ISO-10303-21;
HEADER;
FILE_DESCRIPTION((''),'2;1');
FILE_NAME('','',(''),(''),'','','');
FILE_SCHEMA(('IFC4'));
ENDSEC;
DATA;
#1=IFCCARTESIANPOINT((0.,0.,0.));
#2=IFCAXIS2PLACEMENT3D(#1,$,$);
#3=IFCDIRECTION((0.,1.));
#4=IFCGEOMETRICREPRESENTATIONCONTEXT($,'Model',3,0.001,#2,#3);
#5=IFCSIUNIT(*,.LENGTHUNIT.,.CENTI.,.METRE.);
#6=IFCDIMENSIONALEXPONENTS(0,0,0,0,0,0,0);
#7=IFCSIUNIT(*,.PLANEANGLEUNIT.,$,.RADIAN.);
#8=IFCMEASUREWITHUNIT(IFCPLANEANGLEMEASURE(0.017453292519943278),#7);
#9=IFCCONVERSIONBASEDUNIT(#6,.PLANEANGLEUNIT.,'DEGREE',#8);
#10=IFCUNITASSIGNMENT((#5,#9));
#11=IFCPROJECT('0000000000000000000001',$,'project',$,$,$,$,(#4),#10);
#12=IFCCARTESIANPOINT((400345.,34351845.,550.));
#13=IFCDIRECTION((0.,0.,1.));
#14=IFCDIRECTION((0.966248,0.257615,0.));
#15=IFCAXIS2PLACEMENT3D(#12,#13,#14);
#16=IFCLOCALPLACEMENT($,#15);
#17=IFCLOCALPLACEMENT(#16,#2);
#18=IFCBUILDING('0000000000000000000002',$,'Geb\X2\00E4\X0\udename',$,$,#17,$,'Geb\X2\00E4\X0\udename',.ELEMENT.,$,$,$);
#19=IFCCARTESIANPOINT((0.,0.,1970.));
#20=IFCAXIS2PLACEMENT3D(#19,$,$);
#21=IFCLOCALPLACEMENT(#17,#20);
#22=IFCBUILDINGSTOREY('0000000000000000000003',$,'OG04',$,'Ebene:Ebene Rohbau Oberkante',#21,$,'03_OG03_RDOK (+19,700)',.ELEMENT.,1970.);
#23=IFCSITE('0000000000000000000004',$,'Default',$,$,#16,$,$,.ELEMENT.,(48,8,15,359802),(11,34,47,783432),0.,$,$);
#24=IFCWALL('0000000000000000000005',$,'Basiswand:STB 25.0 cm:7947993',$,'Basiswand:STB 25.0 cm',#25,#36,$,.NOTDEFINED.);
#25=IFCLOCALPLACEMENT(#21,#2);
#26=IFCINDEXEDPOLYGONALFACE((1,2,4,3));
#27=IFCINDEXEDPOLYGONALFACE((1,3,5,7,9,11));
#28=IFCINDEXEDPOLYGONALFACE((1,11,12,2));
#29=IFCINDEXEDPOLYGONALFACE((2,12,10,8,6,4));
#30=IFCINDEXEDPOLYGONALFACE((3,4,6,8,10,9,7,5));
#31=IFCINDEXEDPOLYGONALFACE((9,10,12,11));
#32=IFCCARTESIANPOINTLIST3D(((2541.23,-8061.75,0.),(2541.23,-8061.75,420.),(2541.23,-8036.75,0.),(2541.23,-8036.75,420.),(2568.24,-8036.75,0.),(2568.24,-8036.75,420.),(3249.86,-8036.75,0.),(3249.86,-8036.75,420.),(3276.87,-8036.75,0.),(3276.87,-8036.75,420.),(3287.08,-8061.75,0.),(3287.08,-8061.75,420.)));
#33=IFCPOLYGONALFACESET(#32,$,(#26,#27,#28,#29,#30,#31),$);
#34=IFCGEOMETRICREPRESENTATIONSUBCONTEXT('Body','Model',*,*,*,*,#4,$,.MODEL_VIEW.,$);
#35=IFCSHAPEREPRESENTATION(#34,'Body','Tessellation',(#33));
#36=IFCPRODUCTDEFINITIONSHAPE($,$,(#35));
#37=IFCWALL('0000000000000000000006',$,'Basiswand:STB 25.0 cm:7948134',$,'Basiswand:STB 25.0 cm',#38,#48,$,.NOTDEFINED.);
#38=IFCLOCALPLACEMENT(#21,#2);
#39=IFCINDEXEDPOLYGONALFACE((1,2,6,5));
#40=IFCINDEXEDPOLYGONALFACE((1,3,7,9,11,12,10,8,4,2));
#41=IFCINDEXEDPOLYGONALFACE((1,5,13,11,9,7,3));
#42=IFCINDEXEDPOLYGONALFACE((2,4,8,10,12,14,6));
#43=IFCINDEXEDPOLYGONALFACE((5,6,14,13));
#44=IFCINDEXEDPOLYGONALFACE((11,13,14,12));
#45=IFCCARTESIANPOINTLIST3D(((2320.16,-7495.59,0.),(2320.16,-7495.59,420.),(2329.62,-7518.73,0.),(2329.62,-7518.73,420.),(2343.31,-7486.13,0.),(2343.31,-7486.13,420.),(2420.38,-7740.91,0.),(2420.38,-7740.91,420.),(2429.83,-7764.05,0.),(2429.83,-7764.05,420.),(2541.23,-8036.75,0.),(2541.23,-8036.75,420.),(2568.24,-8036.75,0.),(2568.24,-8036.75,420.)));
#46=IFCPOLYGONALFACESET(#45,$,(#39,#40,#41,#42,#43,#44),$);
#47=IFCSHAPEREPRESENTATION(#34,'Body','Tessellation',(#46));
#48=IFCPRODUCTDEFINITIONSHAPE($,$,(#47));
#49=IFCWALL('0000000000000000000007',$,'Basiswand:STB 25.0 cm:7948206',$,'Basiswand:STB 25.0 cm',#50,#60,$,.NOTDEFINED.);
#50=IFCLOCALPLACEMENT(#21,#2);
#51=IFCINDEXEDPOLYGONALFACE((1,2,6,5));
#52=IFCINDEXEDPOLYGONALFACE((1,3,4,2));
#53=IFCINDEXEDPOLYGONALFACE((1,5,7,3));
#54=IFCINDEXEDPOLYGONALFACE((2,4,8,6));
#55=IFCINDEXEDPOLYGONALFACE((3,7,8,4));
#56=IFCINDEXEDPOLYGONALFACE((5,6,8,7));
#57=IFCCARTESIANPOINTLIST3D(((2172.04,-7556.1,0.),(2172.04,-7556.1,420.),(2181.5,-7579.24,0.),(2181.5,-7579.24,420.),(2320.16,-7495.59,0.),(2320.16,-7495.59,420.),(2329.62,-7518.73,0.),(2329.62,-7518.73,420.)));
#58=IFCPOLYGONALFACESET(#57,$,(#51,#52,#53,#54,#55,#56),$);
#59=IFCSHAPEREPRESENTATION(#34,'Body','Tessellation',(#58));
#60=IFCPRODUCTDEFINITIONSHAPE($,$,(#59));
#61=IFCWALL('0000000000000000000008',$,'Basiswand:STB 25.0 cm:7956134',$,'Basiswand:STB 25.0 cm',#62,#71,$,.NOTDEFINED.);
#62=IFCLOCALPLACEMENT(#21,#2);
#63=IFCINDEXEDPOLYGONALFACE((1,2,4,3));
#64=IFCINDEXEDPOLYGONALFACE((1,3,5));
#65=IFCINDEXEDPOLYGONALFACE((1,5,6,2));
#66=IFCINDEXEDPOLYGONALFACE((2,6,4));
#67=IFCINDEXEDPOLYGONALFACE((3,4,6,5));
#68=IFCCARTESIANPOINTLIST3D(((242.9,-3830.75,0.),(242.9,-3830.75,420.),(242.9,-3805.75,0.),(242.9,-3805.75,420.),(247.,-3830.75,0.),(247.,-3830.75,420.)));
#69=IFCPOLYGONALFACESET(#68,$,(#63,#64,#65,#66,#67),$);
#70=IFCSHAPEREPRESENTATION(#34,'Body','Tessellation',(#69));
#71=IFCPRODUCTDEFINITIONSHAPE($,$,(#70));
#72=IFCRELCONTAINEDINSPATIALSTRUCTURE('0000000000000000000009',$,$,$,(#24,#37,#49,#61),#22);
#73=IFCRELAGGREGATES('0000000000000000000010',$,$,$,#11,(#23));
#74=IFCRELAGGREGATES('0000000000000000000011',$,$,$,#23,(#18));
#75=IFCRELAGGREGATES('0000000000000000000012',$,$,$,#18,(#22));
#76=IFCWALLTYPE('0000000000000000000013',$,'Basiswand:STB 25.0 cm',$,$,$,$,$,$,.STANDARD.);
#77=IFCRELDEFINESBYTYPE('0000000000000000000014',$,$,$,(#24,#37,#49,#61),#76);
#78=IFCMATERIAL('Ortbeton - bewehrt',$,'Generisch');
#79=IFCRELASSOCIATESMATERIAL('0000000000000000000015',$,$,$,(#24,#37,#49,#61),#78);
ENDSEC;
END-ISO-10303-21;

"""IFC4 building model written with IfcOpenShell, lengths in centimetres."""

from ifc_helpers import new_model, entity, si_unit, converted_unit, direction, frame, origin, place, context, subcontext, project, spatial, indexed_curve, outline, extrude, material, type_object, element, save


model = new_model("IFC4")

# Units and contexts
model_context = context("Model", 3, precision=0.001, world=origin(), true_north=direction((0.0, 1.0)))
body_context = subcontext(model_context, "Body", "Model", "MODEL_VIEW")
ifc_project = project(units=[si_unit("LENGTHUNIT", "METRE", prefix="CENTI"), converted_unit("PLANEANGLEUNIT", "DEGREE", entity("IfcPlaneAngleMeasure", 0.017453292519943278), si_unit("PLANEANGLEUNIT", "RADIAN"), dimensions=[0, 0, 0, 0, 0, 0, 0])], contexts=[model_context])

# Site, building, storey
site_placement = place(None, frame((400345.0, 34351845.0, 550.0), z_axis=(0.0, 0.0, 1.0), x_axis=(0.966248, 0.257615, 0.0)))
site = spatial("IfcSite", under=ifc_project, at=site_placement, Name="Default", CompositionType="ELEMENT", RefLatitude=(48, 8, 15, 359802), RefLongitude=(11, 34, 47, 783432), RefElevation=0.0)
building_placement = place(site_placement, origin())
building = spatial("IfcBuilding", under=site, at=building_placement, Name="Gebäudename", LongName="Gebäudename", CompositionType="ELEMENT")
storey_placement = place(building_placement, frame((0.0, 0.0, 1970.0)))
storey = spatial("IfcBuildingStorey", under=building, at=storey_placement, Name="OG04", ObjectType="Ebene:Ebene Rohbau Oberkante", LongName="03_OG03_RDOK (+19,700)", CompositionType="ELEMENT", Elevation=1970.0)

# Shared definitions
ifc_material = material(Name="Ortbeton - bewehrt", Category="Generisch")

# Walls
wall_type = type_object("IfcWallType", Name="Basiswand:STB 25.0 cm", PredefinedType="STANDARD")
wall_1_placement = place(storey_placement, frame((3287.08, -8049.25, 0.0), z_axis=(0.0, 0.0, 1.0), x_axis=(-1.0, 0.0, 0.0)))
element("IfcWall", 1, at=wall_1_placement, inside=storey, type_object=wall_type, material=ifc_material, Name="Basiswand:STB 25.0 cm:7947993", ObjectType="Basiswand:STB 25.0 cm", PredefinedType="NOTDEFINED", context=body_context, shape_type="SweptSolid", body=[
    extrude(outline(indexed_curve([(745.85, -12.5), (745.85, 12.5), (0.0, 12.5), (10.21, -12.5), (37.22, -12.5), (718.84, -12.5), (745.85, -12.5)], self_intersect=False)), origin(), (0.0, 0.0, 1.0), 420.0),
])
wall_2_placement = place(storey_placement, frame((2331.73, -7490.86, 0.0), z_axis=(0.0, 0.0, 1.0), x_axis=(0.378175, -0.925734, 0.0)))
element("IfcWall", 2, at=wall_2_placement, inside=storey, type_object=wall_type, material=ifc_material, Name="Basiswand:STB 25.0 cm:7948134", ObjectType="Basiswand:STB 25.0 cm", PredefinedType="NOTDEFINED", context=body_context, shape_type="SweptSolid", body=[
    extrude(outline(indexed_curve([(584.57, -12.5), (594.78, 12.5), (0.0, 12.5), (0.0, -12.5), (25.0, -12.5), (265.0, -12.5), (290.0, -12.5), (584.57, -12.5)], self_intersect=False)), origin(), (0.0, 0.0, 1.0), 420.0),
])
wall_3_placement = place(storey_placement, frame((2176.77, -7567.67, 0.0), z_axis=(0.0, 0.0, 1.0), x_axis=(0.925734, 0.378175, 0.0)))
element("IfcWall", 3, at=wall_3_placement, inside=storey, type_object=wall_type, material=ifc_material, Name="Basiswand:STB 25.0 cm:7948206", ObjectType="Basiswand:STB 25.0 cm", PredefinedType="NOTDEFINED", context=body_context, shape_type="SweptSolid", body=[
    extrude(outline(indexed_curve([(160.0, 12.5), (0.0, 12.5), (0.0, -12.5), (160.0, -12.5), (160.0, 12.5)], self_intersect=False)), origin(), (0.0, 0.0, 1.0), 420.0),
])
wall_4_placement = place(storey_placement, frame((242.9, -3818.25, 0.0)))
element("IfcWall", 4, at=wall_4_placement, inside=storey, type_object=wall_type, material=ifc_material, Name="Basiswand:STB 25.0 cm:7956134", ObjectType="Basiswand:STB 25.0 cm", PredefinedType="NOTDEFINED", context=body_context, shape_type="SweptSolid", body=[
    extrude(outline(indexed_curve([(4.1, -12.5), (0.0, 12.5), (0.0, -12.5), (4.1, -12.5)], self_intersect=False)), origin(), (0.0, 0.0, 1.0), 420.0),
])

save(model, "model.ifc")
